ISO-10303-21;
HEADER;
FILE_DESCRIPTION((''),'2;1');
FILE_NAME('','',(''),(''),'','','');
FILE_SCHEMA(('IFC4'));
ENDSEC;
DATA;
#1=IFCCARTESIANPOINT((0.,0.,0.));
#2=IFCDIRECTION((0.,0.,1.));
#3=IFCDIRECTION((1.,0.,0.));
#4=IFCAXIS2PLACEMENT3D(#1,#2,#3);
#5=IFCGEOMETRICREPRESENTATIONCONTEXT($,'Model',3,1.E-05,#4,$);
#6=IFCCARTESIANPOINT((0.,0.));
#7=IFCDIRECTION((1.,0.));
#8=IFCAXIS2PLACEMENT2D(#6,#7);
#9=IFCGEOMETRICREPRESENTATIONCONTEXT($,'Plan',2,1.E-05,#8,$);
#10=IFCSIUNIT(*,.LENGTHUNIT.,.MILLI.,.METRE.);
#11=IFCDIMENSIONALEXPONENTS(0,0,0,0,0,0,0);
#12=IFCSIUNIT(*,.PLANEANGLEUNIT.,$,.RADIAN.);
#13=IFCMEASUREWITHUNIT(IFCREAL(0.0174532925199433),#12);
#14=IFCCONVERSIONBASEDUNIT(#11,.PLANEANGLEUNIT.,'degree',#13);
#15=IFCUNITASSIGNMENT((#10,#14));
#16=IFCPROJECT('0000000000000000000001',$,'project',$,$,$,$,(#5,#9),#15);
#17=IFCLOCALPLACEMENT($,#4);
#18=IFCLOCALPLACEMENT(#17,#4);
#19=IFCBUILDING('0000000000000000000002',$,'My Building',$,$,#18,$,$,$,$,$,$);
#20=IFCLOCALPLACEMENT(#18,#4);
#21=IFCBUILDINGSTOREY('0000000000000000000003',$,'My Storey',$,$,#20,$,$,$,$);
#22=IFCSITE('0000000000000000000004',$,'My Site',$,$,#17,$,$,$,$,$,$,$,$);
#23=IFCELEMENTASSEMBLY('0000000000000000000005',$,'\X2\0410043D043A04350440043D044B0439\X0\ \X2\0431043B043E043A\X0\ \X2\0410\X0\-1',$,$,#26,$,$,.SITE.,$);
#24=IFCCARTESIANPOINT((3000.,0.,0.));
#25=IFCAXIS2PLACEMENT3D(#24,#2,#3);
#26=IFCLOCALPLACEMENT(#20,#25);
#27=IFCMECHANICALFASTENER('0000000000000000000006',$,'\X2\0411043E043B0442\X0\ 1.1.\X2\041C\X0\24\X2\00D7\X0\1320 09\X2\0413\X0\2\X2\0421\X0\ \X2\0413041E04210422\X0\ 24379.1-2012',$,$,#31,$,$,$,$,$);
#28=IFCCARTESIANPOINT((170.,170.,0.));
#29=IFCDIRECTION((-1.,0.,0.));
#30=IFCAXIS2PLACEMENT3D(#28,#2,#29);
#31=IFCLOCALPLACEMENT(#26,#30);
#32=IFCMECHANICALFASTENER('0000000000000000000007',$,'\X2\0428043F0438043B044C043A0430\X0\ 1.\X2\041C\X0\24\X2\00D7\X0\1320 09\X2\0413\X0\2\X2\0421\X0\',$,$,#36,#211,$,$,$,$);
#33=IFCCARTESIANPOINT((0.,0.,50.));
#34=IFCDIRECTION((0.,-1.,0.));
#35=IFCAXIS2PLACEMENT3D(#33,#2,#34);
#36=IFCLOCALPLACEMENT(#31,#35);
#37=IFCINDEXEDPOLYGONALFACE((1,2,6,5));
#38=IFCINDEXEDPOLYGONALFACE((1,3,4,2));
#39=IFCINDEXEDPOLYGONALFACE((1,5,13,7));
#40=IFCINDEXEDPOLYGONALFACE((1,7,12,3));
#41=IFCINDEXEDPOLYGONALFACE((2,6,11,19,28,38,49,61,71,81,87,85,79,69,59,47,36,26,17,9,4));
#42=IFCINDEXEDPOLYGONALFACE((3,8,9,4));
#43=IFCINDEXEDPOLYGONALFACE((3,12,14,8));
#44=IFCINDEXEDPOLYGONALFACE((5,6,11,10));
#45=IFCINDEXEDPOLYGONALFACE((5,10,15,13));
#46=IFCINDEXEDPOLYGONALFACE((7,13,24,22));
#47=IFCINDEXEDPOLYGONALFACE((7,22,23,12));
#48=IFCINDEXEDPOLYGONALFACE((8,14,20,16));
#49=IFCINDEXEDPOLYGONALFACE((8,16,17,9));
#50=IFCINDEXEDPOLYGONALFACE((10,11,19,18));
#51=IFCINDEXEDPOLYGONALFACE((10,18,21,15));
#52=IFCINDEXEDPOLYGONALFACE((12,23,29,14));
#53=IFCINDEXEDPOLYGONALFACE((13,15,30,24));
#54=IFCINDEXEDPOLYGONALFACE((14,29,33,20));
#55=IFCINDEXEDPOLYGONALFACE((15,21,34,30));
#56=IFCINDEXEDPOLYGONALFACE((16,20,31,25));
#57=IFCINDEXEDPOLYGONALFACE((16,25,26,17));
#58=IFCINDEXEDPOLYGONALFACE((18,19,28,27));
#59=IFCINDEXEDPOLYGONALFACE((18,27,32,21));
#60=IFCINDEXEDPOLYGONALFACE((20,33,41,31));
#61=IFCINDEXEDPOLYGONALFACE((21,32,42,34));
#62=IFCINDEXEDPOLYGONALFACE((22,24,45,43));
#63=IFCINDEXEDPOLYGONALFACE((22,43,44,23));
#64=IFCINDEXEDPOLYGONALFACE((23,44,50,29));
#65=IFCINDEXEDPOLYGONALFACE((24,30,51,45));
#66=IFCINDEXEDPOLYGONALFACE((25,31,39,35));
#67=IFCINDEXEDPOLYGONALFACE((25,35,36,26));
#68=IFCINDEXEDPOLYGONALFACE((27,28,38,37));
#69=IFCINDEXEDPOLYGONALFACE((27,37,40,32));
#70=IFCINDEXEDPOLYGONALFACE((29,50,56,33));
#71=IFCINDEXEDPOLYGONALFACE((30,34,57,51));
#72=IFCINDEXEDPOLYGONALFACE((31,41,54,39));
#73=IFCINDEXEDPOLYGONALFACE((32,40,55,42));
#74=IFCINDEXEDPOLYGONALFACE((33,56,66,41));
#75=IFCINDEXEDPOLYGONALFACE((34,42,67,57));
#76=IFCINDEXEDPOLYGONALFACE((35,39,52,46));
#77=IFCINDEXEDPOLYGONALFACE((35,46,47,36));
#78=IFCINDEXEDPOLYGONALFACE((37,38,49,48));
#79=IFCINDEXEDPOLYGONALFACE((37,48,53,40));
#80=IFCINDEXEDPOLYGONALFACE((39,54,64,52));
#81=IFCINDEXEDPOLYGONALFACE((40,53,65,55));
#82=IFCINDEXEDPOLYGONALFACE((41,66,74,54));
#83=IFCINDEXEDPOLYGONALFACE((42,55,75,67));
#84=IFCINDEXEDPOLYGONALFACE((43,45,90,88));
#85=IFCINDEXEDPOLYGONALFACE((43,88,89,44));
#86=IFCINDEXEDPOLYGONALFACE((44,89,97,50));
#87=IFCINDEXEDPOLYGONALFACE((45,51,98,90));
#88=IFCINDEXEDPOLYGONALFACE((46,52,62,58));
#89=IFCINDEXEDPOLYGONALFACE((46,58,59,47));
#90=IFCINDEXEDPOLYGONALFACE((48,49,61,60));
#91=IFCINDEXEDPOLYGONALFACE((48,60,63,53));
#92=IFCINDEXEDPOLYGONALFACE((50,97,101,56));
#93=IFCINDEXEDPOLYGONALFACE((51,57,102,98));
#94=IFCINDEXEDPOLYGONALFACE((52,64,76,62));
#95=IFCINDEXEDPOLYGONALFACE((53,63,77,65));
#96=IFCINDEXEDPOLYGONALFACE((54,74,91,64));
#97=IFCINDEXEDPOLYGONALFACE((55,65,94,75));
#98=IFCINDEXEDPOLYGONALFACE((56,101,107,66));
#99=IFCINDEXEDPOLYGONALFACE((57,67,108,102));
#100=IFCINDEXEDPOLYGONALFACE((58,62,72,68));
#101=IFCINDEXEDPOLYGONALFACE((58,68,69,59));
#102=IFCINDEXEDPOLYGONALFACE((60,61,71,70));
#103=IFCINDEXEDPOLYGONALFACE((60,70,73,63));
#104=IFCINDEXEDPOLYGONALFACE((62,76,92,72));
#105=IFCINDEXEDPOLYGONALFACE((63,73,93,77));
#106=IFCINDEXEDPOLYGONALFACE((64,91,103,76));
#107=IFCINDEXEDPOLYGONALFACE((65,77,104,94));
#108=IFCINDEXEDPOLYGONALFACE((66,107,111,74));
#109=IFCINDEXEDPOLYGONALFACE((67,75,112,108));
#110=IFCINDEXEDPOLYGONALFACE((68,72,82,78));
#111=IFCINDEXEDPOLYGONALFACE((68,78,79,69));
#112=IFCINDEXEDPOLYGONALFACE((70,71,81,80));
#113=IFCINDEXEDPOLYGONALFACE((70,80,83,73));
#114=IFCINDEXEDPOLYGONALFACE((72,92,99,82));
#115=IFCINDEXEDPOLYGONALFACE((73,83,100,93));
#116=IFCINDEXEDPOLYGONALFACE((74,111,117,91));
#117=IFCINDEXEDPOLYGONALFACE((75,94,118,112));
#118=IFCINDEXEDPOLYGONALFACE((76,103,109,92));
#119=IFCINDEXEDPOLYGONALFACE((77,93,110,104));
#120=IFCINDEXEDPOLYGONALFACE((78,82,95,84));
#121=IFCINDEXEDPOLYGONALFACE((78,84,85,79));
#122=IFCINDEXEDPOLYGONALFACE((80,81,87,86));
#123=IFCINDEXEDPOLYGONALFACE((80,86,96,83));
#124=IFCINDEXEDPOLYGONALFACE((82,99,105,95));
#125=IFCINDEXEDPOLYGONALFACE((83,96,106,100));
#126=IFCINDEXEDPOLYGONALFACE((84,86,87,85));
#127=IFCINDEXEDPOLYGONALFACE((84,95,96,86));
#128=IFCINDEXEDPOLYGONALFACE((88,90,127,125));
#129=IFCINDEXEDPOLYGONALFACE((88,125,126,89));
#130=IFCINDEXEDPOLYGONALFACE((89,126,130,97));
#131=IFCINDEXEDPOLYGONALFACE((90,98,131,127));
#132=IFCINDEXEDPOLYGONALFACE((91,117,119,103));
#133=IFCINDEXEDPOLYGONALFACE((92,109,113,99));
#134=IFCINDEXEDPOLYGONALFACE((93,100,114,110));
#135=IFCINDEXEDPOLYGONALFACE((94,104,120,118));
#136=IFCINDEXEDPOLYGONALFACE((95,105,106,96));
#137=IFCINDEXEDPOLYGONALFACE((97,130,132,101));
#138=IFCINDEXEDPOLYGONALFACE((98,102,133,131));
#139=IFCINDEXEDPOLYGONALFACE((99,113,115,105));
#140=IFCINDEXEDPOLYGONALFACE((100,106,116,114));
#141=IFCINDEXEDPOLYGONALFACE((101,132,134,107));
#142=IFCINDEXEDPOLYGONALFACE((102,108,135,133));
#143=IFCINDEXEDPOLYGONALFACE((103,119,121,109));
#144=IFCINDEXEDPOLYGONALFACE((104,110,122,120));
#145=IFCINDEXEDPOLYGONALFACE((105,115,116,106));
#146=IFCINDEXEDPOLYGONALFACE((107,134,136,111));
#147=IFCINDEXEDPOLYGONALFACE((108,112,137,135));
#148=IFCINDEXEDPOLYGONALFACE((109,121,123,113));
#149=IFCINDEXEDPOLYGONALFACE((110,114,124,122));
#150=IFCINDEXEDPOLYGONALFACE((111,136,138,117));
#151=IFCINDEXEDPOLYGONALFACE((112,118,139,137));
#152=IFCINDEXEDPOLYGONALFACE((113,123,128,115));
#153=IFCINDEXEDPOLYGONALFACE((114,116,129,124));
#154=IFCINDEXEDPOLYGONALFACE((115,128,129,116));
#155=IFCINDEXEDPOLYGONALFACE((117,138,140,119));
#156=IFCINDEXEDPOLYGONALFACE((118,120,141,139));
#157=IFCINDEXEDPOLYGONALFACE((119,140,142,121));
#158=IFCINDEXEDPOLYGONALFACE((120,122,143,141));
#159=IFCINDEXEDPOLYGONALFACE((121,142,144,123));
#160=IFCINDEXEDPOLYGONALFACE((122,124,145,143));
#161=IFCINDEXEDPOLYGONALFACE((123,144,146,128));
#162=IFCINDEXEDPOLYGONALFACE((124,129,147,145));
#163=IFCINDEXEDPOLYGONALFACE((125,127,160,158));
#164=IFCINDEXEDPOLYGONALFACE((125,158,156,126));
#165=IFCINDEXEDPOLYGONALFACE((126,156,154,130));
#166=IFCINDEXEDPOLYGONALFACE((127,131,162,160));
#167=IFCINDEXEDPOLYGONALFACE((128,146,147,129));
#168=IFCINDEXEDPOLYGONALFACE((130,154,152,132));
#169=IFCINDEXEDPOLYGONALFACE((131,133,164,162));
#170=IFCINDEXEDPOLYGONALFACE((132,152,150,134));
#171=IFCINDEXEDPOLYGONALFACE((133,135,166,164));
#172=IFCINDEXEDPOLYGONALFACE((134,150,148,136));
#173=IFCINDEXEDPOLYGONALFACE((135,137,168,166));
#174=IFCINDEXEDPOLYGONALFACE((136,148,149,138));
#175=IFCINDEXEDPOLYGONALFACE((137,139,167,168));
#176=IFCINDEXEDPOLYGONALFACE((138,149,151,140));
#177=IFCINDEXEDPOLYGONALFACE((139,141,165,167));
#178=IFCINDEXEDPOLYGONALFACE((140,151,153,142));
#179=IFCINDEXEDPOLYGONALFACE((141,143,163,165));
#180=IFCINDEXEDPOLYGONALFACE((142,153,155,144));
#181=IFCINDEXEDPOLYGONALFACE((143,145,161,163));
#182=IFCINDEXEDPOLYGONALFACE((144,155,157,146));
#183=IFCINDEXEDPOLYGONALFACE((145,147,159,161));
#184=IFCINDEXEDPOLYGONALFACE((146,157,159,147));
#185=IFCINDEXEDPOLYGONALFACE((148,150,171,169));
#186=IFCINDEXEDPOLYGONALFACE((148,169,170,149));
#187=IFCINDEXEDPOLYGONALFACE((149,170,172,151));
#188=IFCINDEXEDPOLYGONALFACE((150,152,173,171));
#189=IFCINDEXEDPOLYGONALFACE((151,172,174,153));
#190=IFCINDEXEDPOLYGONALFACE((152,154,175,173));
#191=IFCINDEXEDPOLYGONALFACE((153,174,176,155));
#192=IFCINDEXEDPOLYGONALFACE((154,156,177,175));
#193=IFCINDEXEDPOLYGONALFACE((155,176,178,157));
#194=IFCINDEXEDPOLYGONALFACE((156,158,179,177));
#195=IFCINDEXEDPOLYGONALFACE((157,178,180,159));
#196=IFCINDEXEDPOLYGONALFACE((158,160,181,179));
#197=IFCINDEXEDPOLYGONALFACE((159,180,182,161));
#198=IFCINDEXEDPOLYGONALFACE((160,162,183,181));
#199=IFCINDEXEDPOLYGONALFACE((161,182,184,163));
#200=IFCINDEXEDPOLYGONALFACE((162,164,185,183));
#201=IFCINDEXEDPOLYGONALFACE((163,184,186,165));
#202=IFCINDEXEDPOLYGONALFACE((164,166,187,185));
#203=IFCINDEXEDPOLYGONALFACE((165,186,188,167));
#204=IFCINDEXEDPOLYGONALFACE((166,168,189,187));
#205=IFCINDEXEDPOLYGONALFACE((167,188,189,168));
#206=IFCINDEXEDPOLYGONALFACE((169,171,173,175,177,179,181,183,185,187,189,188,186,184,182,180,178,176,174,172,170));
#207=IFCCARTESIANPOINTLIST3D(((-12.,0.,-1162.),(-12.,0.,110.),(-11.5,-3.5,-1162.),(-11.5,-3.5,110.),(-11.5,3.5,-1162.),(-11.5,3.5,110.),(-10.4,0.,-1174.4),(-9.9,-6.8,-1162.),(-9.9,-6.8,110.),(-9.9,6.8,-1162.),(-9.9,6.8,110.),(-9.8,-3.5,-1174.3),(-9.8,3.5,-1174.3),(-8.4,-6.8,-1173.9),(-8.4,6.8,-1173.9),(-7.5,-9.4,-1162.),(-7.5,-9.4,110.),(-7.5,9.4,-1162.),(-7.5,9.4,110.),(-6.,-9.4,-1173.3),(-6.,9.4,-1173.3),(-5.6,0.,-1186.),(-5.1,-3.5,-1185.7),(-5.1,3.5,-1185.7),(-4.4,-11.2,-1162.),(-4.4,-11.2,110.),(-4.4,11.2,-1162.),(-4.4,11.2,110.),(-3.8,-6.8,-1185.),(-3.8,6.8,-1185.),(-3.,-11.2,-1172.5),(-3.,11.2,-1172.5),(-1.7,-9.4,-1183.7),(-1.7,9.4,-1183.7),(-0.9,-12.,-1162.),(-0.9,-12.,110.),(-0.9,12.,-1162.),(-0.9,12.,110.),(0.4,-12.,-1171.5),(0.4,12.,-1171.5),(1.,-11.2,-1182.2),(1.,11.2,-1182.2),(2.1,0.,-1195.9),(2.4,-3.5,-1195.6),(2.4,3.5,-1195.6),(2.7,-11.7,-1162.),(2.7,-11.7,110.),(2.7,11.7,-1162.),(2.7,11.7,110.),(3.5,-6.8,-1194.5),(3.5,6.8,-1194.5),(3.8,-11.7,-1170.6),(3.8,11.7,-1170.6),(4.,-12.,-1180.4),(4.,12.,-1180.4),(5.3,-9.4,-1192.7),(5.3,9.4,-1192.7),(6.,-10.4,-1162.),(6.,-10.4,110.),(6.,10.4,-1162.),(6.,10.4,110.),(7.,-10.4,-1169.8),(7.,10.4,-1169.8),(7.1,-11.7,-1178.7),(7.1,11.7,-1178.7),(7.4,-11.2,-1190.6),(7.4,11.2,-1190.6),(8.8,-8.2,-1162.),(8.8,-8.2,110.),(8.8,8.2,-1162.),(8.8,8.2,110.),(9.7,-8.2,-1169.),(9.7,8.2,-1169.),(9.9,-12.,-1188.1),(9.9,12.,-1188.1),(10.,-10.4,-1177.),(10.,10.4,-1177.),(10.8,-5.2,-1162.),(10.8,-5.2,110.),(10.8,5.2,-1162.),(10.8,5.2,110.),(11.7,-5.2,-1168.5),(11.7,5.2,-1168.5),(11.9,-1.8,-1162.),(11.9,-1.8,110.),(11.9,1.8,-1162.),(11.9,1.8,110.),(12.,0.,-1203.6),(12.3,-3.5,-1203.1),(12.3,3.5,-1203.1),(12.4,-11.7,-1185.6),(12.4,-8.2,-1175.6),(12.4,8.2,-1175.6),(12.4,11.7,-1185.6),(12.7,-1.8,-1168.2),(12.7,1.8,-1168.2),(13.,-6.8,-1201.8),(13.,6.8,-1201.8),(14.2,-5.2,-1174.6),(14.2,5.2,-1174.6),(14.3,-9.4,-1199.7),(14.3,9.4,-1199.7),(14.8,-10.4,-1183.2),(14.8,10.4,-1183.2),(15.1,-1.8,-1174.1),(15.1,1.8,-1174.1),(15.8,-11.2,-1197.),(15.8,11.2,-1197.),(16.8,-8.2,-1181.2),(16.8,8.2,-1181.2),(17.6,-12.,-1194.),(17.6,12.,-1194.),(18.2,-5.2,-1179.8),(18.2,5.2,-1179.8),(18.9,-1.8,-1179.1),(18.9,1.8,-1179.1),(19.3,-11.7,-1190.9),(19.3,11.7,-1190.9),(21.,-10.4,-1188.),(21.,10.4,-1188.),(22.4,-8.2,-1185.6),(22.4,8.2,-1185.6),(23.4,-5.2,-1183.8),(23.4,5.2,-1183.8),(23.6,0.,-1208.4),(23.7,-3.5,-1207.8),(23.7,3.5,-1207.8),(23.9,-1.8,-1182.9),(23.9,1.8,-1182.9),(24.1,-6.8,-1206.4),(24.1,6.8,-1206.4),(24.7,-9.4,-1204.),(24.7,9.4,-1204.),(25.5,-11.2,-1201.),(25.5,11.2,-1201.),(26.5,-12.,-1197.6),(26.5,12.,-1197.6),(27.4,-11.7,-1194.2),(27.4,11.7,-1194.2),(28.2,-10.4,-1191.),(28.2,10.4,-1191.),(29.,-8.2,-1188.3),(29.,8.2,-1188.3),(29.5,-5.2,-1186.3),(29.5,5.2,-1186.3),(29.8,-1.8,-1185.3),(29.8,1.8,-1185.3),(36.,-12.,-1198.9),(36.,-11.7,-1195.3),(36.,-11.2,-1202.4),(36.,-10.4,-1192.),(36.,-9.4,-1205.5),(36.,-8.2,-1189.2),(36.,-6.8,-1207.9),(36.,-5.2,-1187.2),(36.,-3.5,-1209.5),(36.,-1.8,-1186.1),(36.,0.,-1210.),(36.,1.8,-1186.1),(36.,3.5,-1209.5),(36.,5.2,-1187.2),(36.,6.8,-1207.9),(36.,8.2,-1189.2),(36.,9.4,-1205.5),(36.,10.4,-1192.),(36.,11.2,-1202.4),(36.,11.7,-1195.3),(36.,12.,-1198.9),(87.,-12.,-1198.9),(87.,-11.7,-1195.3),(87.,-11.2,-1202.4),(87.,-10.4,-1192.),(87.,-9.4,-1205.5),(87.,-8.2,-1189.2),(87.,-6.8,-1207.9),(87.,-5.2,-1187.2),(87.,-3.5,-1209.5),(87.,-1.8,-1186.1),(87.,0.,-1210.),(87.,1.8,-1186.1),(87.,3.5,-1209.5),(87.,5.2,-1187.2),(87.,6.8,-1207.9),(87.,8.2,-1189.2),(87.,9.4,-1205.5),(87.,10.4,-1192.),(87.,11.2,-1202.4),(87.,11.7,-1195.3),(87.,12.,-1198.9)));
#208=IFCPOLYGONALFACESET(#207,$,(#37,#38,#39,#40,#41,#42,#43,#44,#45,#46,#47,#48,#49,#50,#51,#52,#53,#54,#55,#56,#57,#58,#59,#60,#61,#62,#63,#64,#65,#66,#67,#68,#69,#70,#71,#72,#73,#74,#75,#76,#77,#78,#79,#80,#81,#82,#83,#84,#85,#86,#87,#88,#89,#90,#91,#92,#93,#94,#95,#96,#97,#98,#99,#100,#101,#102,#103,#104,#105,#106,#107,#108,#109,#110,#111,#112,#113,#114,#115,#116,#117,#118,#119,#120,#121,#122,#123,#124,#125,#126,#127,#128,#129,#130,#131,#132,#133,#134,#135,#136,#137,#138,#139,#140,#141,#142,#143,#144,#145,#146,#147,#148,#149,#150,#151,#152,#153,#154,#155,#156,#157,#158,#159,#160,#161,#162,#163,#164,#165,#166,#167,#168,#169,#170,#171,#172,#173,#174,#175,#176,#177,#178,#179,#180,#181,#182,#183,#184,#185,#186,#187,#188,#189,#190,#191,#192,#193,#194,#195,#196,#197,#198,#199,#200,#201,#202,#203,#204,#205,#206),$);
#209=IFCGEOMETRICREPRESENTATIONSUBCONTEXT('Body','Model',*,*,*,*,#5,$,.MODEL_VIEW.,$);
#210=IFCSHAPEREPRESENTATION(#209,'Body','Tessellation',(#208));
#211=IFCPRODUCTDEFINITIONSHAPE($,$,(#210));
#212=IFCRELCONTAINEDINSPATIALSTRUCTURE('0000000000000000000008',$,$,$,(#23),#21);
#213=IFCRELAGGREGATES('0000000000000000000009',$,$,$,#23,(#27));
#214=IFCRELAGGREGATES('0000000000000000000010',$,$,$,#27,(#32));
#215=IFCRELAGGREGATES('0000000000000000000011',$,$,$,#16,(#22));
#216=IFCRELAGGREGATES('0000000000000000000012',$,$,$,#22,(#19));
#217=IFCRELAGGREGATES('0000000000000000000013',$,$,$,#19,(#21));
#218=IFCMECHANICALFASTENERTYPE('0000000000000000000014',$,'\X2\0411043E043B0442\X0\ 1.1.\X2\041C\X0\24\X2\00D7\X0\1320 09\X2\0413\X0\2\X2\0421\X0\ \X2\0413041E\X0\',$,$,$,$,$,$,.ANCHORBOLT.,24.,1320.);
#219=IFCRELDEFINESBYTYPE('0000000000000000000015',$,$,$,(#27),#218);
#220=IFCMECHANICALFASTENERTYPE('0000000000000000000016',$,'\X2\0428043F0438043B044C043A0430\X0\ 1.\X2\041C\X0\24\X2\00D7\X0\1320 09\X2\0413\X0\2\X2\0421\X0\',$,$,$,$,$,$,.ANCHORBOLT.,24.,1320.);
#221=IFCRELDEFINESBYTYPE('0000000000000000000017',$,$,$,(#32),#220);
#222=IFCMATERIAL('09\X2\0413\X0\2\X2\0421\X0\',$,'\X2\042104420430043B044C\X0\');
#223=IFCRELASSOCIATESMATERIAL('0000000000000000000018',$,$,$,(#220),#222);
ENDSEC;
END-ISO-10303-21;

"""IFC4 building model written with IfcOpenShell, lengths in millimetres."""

from ifc_helpers import new_model, entity, si_unit, converted_unit, frame, origin_with_axes, origin_2d_with_axis, place, context, subcontext, project, spatial, source, transform, mapped, material, type_object, type_shapes, element, aggregate, save


model = new_model("IFC4")

# Units and contexts
model_context = context("Model", 3, precision=1e-05, world=origin_with_axes())
plan_context = context("Plan", 2, precision=1e-05, world=origin_2d_with_axis())
body_context = subcontext(model_context, "Body", "Model", "MODEL_VIEW")
ifc_project = project(units=[si_unit("LENGTHUNIT", "METRE", prefix="MILLI"), converted_unit("PLANEANGLEUNIT", "degree", entity("IfcReal", 0.0174532925199433), si_unit("PLANEANGLEUNIT", "RADIAN"), dimensions=[0, 0, 0, 0, 0, 0, 0])], contexts=[model_context, plan_context])

# Site, building, storey
site_placement = place(None, origin_with_axes())
site = spatial("IfcSite", under=ifc_project, at=site_placement, Name="My Site")
building_placement = place(site_placement, origin_with_axes())
building = spatial("IfcBuilding", under=site, at=building_placement, Name="My Building")
storey_placement = place(building_placement, origin_with_axes())
storey = spatial("IfcBuildingStorey", under=building, at=storey_placement, Name="My Storey")

# Shared definitions
placement = place(storey_placement, frame((3000.0, 0.0, 0.0), z_axis=(0.0, 0.0, 1.0), x_axis=(1.0, 0.0, 0.0)))

# Element assembly, mechanical fasteners
assembly = element("IfcElementAssembly", 1, at=placement, inside=storey, Name="Анкерный блок А-1", AssemblyPlace="SITE")
mechanical_fastener_type_1 = type_object("IfcMechanicalFastenerType", Name="Болт 1.1.М24×1320 09Г2С ГО", NominalDiameter=24.0, NominalLength=1320.0, PredefinedType="ANCHORBOLT")
ifc_material_1 = material(Name="09Г2С", Category="Сталь")
mechanical_fastener_type_2 = type_object("IfcMechanicalFastenerType", Name="Шпилька 1.М24×1320 09Г2С", NominalDiameter=24.0, NominalLength=1320.0, PredefinedType="ANCHORBOLT", material=ifc_material_1)
shared_shape_1 = source(frame((0.0, 0.0, 110.0), z_axis=(0.0, 0.0, 1.0), x_axis=(1.0, 0.0, 0.0)), body_context, "Body", "AdvancedSweptSolid", [
    entity("IfcSweptDiskSolid", entity("IfcIndexedPolyCurve", entity("IfcCartesianPointList3D", [[0.0, 0.0, 0.0], [0.0, 0.0, -1272.0], [10.5, 0.0, -1297.5], [36.0, 0.0, -1308.0], [87.0, 0.0, -1308.0]]), [entity("IfcLineIndex", [1, 2]), entity("IfcArcIndex", [2, 3, 4]), entity("IfcLineIndex", [4, 5])]), 12.0),
])
type_shapes(mechanical_fastener_type_2, [shared_shape_1])
mechanical_fastener_1_placement = place(placement, frame((170.0, 170.0, 0.0), z_axis=(0.0, 0.0, 1.0), x_axis=(-1.0, 0.0, 0.0)))
mechanical_fastener_1 = element("IfcMechanicalFastener", 2, at=mechanical_fastener_1_placement, type_object=mechanical_fastener_type_1, Name="Болт 1.1.М24×1320 09Г2С ГОСТ 24379.1-2012")
aggregate(assembly, [mechanical_fastener_1])
mechanical_fastener_2_placement = place(mechanical_fastener_1_placement, frame((0.0, 0.0, 50.0), z_axis=(0.0, 0.0, 1.0), x_axis=(0.0, -1.0, 0.0)))
mechanical_fastener_2 = element("IfcMechanicalFastener", 3, at=mechanical_fastener_2_placement, type_object=mechanical_fastener_type_2, Name="Шпилька 1.М24×1320 09Г2С", context=body_context, shape_type="MappedRepresentation", body=[
    mapped(shared_shape_1, transform((0.0, 0.0, 0.0), x_axis=(1.0, 0.0, 0.0), y_axis=(0.0, 1.0, 0.0), z_axis=(0.0, 0.0, 1.0), scale=1.0)),
])
aggregate(mechanical_fastener_1, [mechanical_fastener_2])

save(model, "model.ifc")
